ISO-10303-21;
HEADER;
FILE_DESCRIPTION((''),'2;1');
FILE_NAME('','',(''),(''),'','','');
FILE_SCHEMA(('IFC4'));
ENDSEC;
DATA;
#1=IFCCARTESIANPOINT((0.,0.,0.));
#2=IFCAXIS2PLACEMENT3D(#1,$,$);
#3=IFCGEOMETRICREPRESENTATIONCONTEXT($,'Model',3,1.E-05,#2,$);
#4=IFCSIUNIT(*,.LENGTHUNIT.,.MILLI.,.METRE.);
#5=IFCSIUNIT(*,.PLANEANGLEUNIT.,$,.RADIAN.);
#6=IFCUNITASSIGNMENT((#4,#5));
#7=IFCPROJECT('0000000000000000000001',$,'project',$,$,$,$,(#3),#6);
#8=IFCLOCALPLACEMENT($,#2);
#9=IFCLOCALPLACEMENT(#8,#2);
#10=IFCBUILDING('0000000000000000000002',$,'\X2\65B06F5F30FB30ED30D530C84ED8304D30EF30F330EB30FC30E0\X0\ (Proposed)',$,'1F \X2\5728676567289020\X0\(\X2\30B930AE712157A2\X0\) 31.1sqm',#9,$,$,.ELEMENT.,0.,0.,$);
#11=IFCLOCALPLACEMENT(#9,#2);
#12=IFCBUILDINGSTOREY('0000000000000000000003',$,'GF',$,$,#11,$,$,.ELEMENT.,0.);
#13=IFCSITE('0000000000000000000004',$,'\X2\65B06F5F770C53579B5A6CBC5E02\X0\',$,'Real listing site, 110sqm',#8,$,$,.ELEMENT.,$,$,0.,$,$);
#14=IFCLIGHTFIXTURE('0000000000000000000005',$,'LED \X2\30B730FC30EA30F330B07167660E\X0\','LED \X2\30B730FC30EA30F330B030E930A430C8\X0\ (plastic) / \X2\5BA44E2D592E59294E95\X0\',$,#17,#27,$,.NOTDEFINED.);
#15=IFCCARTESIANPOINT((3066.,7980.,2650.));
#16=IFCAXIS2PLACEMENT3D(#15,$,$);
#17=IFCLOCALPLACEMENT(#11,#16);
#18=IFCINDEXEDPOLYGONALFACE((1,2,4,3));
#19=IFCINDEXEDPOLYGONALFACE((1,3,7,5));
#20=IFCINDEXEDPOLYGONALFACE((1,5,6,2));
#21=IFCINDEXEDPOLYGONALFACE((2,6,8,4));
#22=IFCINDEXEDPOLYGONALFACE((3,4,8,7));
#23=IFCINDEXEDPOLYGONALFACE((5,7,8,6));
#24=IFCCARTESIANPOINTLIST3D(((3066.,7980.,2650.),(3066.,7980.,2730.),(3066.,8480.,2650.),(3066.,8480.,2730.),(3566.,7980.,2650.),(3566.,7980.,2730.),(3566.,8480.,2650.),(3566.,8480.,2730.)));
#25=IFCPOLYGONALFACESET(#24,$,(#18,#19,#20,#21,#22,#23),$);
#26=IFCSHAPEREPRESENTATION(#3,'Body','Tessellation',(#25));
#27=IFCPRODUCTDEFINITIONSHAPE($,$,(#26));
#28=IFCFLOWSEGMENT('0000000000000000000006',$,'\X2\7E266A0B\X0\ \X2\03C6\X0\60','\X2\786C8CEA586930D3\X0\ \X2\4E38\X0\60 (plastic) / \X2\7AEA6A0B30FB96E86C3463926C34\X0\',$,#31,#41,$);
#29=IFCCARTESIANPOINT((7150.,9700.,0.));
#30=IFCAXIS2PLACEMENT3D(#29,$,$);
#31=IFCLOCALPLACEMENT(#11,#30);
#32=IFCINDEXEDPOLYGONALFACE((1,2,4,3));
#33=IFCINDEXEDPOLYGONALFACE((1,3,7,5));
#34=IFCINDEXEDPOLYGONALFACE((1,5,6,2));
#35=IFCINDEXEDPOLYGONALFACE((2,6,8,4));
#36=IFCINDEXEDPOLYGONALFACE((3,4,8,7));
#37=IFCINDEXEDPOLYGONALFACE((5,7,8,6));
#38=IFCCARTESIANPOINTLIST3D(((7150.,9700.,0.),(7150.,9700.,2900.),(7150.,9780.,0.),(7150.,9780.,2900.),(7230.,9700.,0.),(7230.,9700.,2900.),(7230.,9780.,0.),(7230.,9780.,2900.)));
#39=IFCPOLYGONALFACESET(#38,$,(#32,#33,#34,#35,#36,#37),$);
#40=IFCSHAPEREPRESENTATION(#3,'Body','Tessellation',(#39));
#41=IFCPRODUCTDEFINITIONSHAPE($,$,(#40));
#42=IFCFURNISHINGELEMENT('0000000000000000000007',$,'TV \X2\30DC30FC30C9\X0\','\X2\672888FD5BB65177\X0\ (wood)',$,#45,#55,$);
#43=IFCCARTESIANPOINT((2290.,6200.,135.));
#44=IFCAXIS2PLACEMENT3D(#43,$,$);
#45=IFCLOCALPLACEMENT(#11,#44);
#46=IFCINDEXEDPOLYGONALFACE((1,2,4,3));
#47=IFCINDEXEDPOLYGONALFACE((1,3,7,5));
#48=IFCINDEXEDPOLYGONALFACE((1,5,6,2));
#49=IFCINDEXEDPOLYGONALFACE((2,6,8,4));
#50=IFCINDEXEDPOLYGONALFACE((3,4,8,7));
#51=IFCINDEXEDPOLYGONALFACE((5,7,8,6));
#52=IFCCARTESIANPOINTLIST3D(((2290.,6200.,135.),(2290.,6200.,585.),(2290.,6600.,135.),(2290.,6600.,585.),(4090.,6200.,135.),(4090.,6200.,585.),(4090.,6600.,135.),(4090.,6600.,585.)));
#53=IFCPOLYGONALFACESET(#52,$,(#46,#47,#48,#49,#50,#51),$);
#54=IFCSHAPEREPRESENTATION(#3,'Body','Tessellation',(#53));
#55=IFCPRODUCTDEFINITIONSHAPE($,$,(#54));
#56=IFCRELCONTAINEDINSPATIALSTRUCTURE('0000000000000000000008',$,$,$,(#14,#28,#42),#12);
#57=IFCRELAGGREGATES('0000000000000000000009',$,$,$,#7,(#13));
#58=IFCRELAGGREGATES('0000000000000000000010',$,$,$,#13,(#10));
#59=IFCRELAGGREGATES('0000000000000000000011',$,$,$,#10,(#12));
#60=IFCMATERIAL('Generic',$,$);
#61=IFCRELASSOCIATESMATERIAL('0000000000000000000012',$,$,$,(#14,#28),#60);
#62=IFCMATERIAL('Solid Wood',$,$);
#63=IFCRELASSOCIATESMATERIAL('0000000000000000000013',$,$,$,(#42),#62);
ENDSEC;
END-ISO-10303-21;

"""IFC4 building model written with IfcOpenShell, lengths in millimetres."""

from ifc_helpers import new_model, si_unit, frame, frame_2d, origin, place, context, project, spatial, rectangle, extrude, material, element, save


model = new_model("IFC4")

# Units and contexts
model_context = context("Model", 3, precision=1e-05, world=origin())
ifc_project = project(units=[si_unit("LENGTHUNIT", "METRE", prefix="MILLI"), si_unit("PLANEANGLEUNIT", "RADIAN")], contexts=[model_context])

# Site, building, storey
site_placement = place(None, origin())
site = spatial("IfcSite", under=ifc_project, at=site_placement, Name="新潟県南魚沼市", ObjectType="Real listing site, 110sqm", CompositionType="ELEMENT", RefElevation=0.0)
building_placement = place(site_placement, origin())
building = spatial("IfcBuilding", under=site, at=building_placement, Name="新潟・ロフト付きワンルーム (Proposed)", ObjectType="1F 在来木造(スギ無垢) 31.1sqm", CompositionType="ELEMENT", ElevationOfRefHeight=0.0, ElevationOfTerrain=0.0)
storey_placement = place(building_placement, origin())
storey = spatial("IfcBuildingStorey", under=building, at=storey_placement, Name="GF", CompositionType="ELEMENT", Elevation=0.0)

# Shared definitions
ifc_material_1 = material(Name="Solid Wood")

# Shared definitions
ifc_material_2 = material(Name="Generic")

# Light fixture
light_fixture_1_placement = place(storey_placement, frame((3066.0, 7980.0, 2650.0)))
element("IfcLightFixture", 1, at=light_fixture_1_placement, inside=storey, material=ifc_material_2, Name="LED シーリング照明", Description="LED シーリングライト (plastic) / 室中央天井", PredefinedType="NOTDEFINED", context=model_context, shape_type="SweptSolid", body=[
    extrude(rectangle(XDim=500.0, YDim=500.0, at=frame_2d((250.0, 250.0))), frame((3066.0, 7980.0, 2650.0)), (0.0, 0.0, 1.0), 80.0),
])

# Flow segment
flow_segment_placement = place(storey_placement, frame((7150.0, 9700.0, 0.0)))
element("IfcFlowSegment", 2, at=flow_segment_placement, inside=storey, material=ifc_material_2, Name="縦樋 φ60", Description="硬質塩ビ 丸60 (plastic) / 竪樋・雨水排水", context=model_context, shape_type="SweptSolid", body=[
    extrude(rectangle(XDim=80.0, YDim=80.0, at=frame_2d((40.0, 40.0))), frame((7150.0, 9700.0, 0.0)), (0.0, 0.0, 1.0), 2900.0),
])

# Furnishing element
furnishing_placement = place(storey_placement, frame((2290.0, 6200.0, 135.0)))
element("IfcFurnishingElement", 3, at=furnishing_placement, inside=storey, material=ifc_material_1, Name="TV ボード", Description="木製家具 (wood)", context=model_context, shape_type="SweptSolid", body=[
    extrude(rectangle(XDim=1800.0, YDim=400.0, at=frame_2d((900.0, 200.0))), frame((2290.0, 6200.0, 135.0)), (0.0, 0.0, 1.0), 450.0),
])

save(model, "model.ifc")
